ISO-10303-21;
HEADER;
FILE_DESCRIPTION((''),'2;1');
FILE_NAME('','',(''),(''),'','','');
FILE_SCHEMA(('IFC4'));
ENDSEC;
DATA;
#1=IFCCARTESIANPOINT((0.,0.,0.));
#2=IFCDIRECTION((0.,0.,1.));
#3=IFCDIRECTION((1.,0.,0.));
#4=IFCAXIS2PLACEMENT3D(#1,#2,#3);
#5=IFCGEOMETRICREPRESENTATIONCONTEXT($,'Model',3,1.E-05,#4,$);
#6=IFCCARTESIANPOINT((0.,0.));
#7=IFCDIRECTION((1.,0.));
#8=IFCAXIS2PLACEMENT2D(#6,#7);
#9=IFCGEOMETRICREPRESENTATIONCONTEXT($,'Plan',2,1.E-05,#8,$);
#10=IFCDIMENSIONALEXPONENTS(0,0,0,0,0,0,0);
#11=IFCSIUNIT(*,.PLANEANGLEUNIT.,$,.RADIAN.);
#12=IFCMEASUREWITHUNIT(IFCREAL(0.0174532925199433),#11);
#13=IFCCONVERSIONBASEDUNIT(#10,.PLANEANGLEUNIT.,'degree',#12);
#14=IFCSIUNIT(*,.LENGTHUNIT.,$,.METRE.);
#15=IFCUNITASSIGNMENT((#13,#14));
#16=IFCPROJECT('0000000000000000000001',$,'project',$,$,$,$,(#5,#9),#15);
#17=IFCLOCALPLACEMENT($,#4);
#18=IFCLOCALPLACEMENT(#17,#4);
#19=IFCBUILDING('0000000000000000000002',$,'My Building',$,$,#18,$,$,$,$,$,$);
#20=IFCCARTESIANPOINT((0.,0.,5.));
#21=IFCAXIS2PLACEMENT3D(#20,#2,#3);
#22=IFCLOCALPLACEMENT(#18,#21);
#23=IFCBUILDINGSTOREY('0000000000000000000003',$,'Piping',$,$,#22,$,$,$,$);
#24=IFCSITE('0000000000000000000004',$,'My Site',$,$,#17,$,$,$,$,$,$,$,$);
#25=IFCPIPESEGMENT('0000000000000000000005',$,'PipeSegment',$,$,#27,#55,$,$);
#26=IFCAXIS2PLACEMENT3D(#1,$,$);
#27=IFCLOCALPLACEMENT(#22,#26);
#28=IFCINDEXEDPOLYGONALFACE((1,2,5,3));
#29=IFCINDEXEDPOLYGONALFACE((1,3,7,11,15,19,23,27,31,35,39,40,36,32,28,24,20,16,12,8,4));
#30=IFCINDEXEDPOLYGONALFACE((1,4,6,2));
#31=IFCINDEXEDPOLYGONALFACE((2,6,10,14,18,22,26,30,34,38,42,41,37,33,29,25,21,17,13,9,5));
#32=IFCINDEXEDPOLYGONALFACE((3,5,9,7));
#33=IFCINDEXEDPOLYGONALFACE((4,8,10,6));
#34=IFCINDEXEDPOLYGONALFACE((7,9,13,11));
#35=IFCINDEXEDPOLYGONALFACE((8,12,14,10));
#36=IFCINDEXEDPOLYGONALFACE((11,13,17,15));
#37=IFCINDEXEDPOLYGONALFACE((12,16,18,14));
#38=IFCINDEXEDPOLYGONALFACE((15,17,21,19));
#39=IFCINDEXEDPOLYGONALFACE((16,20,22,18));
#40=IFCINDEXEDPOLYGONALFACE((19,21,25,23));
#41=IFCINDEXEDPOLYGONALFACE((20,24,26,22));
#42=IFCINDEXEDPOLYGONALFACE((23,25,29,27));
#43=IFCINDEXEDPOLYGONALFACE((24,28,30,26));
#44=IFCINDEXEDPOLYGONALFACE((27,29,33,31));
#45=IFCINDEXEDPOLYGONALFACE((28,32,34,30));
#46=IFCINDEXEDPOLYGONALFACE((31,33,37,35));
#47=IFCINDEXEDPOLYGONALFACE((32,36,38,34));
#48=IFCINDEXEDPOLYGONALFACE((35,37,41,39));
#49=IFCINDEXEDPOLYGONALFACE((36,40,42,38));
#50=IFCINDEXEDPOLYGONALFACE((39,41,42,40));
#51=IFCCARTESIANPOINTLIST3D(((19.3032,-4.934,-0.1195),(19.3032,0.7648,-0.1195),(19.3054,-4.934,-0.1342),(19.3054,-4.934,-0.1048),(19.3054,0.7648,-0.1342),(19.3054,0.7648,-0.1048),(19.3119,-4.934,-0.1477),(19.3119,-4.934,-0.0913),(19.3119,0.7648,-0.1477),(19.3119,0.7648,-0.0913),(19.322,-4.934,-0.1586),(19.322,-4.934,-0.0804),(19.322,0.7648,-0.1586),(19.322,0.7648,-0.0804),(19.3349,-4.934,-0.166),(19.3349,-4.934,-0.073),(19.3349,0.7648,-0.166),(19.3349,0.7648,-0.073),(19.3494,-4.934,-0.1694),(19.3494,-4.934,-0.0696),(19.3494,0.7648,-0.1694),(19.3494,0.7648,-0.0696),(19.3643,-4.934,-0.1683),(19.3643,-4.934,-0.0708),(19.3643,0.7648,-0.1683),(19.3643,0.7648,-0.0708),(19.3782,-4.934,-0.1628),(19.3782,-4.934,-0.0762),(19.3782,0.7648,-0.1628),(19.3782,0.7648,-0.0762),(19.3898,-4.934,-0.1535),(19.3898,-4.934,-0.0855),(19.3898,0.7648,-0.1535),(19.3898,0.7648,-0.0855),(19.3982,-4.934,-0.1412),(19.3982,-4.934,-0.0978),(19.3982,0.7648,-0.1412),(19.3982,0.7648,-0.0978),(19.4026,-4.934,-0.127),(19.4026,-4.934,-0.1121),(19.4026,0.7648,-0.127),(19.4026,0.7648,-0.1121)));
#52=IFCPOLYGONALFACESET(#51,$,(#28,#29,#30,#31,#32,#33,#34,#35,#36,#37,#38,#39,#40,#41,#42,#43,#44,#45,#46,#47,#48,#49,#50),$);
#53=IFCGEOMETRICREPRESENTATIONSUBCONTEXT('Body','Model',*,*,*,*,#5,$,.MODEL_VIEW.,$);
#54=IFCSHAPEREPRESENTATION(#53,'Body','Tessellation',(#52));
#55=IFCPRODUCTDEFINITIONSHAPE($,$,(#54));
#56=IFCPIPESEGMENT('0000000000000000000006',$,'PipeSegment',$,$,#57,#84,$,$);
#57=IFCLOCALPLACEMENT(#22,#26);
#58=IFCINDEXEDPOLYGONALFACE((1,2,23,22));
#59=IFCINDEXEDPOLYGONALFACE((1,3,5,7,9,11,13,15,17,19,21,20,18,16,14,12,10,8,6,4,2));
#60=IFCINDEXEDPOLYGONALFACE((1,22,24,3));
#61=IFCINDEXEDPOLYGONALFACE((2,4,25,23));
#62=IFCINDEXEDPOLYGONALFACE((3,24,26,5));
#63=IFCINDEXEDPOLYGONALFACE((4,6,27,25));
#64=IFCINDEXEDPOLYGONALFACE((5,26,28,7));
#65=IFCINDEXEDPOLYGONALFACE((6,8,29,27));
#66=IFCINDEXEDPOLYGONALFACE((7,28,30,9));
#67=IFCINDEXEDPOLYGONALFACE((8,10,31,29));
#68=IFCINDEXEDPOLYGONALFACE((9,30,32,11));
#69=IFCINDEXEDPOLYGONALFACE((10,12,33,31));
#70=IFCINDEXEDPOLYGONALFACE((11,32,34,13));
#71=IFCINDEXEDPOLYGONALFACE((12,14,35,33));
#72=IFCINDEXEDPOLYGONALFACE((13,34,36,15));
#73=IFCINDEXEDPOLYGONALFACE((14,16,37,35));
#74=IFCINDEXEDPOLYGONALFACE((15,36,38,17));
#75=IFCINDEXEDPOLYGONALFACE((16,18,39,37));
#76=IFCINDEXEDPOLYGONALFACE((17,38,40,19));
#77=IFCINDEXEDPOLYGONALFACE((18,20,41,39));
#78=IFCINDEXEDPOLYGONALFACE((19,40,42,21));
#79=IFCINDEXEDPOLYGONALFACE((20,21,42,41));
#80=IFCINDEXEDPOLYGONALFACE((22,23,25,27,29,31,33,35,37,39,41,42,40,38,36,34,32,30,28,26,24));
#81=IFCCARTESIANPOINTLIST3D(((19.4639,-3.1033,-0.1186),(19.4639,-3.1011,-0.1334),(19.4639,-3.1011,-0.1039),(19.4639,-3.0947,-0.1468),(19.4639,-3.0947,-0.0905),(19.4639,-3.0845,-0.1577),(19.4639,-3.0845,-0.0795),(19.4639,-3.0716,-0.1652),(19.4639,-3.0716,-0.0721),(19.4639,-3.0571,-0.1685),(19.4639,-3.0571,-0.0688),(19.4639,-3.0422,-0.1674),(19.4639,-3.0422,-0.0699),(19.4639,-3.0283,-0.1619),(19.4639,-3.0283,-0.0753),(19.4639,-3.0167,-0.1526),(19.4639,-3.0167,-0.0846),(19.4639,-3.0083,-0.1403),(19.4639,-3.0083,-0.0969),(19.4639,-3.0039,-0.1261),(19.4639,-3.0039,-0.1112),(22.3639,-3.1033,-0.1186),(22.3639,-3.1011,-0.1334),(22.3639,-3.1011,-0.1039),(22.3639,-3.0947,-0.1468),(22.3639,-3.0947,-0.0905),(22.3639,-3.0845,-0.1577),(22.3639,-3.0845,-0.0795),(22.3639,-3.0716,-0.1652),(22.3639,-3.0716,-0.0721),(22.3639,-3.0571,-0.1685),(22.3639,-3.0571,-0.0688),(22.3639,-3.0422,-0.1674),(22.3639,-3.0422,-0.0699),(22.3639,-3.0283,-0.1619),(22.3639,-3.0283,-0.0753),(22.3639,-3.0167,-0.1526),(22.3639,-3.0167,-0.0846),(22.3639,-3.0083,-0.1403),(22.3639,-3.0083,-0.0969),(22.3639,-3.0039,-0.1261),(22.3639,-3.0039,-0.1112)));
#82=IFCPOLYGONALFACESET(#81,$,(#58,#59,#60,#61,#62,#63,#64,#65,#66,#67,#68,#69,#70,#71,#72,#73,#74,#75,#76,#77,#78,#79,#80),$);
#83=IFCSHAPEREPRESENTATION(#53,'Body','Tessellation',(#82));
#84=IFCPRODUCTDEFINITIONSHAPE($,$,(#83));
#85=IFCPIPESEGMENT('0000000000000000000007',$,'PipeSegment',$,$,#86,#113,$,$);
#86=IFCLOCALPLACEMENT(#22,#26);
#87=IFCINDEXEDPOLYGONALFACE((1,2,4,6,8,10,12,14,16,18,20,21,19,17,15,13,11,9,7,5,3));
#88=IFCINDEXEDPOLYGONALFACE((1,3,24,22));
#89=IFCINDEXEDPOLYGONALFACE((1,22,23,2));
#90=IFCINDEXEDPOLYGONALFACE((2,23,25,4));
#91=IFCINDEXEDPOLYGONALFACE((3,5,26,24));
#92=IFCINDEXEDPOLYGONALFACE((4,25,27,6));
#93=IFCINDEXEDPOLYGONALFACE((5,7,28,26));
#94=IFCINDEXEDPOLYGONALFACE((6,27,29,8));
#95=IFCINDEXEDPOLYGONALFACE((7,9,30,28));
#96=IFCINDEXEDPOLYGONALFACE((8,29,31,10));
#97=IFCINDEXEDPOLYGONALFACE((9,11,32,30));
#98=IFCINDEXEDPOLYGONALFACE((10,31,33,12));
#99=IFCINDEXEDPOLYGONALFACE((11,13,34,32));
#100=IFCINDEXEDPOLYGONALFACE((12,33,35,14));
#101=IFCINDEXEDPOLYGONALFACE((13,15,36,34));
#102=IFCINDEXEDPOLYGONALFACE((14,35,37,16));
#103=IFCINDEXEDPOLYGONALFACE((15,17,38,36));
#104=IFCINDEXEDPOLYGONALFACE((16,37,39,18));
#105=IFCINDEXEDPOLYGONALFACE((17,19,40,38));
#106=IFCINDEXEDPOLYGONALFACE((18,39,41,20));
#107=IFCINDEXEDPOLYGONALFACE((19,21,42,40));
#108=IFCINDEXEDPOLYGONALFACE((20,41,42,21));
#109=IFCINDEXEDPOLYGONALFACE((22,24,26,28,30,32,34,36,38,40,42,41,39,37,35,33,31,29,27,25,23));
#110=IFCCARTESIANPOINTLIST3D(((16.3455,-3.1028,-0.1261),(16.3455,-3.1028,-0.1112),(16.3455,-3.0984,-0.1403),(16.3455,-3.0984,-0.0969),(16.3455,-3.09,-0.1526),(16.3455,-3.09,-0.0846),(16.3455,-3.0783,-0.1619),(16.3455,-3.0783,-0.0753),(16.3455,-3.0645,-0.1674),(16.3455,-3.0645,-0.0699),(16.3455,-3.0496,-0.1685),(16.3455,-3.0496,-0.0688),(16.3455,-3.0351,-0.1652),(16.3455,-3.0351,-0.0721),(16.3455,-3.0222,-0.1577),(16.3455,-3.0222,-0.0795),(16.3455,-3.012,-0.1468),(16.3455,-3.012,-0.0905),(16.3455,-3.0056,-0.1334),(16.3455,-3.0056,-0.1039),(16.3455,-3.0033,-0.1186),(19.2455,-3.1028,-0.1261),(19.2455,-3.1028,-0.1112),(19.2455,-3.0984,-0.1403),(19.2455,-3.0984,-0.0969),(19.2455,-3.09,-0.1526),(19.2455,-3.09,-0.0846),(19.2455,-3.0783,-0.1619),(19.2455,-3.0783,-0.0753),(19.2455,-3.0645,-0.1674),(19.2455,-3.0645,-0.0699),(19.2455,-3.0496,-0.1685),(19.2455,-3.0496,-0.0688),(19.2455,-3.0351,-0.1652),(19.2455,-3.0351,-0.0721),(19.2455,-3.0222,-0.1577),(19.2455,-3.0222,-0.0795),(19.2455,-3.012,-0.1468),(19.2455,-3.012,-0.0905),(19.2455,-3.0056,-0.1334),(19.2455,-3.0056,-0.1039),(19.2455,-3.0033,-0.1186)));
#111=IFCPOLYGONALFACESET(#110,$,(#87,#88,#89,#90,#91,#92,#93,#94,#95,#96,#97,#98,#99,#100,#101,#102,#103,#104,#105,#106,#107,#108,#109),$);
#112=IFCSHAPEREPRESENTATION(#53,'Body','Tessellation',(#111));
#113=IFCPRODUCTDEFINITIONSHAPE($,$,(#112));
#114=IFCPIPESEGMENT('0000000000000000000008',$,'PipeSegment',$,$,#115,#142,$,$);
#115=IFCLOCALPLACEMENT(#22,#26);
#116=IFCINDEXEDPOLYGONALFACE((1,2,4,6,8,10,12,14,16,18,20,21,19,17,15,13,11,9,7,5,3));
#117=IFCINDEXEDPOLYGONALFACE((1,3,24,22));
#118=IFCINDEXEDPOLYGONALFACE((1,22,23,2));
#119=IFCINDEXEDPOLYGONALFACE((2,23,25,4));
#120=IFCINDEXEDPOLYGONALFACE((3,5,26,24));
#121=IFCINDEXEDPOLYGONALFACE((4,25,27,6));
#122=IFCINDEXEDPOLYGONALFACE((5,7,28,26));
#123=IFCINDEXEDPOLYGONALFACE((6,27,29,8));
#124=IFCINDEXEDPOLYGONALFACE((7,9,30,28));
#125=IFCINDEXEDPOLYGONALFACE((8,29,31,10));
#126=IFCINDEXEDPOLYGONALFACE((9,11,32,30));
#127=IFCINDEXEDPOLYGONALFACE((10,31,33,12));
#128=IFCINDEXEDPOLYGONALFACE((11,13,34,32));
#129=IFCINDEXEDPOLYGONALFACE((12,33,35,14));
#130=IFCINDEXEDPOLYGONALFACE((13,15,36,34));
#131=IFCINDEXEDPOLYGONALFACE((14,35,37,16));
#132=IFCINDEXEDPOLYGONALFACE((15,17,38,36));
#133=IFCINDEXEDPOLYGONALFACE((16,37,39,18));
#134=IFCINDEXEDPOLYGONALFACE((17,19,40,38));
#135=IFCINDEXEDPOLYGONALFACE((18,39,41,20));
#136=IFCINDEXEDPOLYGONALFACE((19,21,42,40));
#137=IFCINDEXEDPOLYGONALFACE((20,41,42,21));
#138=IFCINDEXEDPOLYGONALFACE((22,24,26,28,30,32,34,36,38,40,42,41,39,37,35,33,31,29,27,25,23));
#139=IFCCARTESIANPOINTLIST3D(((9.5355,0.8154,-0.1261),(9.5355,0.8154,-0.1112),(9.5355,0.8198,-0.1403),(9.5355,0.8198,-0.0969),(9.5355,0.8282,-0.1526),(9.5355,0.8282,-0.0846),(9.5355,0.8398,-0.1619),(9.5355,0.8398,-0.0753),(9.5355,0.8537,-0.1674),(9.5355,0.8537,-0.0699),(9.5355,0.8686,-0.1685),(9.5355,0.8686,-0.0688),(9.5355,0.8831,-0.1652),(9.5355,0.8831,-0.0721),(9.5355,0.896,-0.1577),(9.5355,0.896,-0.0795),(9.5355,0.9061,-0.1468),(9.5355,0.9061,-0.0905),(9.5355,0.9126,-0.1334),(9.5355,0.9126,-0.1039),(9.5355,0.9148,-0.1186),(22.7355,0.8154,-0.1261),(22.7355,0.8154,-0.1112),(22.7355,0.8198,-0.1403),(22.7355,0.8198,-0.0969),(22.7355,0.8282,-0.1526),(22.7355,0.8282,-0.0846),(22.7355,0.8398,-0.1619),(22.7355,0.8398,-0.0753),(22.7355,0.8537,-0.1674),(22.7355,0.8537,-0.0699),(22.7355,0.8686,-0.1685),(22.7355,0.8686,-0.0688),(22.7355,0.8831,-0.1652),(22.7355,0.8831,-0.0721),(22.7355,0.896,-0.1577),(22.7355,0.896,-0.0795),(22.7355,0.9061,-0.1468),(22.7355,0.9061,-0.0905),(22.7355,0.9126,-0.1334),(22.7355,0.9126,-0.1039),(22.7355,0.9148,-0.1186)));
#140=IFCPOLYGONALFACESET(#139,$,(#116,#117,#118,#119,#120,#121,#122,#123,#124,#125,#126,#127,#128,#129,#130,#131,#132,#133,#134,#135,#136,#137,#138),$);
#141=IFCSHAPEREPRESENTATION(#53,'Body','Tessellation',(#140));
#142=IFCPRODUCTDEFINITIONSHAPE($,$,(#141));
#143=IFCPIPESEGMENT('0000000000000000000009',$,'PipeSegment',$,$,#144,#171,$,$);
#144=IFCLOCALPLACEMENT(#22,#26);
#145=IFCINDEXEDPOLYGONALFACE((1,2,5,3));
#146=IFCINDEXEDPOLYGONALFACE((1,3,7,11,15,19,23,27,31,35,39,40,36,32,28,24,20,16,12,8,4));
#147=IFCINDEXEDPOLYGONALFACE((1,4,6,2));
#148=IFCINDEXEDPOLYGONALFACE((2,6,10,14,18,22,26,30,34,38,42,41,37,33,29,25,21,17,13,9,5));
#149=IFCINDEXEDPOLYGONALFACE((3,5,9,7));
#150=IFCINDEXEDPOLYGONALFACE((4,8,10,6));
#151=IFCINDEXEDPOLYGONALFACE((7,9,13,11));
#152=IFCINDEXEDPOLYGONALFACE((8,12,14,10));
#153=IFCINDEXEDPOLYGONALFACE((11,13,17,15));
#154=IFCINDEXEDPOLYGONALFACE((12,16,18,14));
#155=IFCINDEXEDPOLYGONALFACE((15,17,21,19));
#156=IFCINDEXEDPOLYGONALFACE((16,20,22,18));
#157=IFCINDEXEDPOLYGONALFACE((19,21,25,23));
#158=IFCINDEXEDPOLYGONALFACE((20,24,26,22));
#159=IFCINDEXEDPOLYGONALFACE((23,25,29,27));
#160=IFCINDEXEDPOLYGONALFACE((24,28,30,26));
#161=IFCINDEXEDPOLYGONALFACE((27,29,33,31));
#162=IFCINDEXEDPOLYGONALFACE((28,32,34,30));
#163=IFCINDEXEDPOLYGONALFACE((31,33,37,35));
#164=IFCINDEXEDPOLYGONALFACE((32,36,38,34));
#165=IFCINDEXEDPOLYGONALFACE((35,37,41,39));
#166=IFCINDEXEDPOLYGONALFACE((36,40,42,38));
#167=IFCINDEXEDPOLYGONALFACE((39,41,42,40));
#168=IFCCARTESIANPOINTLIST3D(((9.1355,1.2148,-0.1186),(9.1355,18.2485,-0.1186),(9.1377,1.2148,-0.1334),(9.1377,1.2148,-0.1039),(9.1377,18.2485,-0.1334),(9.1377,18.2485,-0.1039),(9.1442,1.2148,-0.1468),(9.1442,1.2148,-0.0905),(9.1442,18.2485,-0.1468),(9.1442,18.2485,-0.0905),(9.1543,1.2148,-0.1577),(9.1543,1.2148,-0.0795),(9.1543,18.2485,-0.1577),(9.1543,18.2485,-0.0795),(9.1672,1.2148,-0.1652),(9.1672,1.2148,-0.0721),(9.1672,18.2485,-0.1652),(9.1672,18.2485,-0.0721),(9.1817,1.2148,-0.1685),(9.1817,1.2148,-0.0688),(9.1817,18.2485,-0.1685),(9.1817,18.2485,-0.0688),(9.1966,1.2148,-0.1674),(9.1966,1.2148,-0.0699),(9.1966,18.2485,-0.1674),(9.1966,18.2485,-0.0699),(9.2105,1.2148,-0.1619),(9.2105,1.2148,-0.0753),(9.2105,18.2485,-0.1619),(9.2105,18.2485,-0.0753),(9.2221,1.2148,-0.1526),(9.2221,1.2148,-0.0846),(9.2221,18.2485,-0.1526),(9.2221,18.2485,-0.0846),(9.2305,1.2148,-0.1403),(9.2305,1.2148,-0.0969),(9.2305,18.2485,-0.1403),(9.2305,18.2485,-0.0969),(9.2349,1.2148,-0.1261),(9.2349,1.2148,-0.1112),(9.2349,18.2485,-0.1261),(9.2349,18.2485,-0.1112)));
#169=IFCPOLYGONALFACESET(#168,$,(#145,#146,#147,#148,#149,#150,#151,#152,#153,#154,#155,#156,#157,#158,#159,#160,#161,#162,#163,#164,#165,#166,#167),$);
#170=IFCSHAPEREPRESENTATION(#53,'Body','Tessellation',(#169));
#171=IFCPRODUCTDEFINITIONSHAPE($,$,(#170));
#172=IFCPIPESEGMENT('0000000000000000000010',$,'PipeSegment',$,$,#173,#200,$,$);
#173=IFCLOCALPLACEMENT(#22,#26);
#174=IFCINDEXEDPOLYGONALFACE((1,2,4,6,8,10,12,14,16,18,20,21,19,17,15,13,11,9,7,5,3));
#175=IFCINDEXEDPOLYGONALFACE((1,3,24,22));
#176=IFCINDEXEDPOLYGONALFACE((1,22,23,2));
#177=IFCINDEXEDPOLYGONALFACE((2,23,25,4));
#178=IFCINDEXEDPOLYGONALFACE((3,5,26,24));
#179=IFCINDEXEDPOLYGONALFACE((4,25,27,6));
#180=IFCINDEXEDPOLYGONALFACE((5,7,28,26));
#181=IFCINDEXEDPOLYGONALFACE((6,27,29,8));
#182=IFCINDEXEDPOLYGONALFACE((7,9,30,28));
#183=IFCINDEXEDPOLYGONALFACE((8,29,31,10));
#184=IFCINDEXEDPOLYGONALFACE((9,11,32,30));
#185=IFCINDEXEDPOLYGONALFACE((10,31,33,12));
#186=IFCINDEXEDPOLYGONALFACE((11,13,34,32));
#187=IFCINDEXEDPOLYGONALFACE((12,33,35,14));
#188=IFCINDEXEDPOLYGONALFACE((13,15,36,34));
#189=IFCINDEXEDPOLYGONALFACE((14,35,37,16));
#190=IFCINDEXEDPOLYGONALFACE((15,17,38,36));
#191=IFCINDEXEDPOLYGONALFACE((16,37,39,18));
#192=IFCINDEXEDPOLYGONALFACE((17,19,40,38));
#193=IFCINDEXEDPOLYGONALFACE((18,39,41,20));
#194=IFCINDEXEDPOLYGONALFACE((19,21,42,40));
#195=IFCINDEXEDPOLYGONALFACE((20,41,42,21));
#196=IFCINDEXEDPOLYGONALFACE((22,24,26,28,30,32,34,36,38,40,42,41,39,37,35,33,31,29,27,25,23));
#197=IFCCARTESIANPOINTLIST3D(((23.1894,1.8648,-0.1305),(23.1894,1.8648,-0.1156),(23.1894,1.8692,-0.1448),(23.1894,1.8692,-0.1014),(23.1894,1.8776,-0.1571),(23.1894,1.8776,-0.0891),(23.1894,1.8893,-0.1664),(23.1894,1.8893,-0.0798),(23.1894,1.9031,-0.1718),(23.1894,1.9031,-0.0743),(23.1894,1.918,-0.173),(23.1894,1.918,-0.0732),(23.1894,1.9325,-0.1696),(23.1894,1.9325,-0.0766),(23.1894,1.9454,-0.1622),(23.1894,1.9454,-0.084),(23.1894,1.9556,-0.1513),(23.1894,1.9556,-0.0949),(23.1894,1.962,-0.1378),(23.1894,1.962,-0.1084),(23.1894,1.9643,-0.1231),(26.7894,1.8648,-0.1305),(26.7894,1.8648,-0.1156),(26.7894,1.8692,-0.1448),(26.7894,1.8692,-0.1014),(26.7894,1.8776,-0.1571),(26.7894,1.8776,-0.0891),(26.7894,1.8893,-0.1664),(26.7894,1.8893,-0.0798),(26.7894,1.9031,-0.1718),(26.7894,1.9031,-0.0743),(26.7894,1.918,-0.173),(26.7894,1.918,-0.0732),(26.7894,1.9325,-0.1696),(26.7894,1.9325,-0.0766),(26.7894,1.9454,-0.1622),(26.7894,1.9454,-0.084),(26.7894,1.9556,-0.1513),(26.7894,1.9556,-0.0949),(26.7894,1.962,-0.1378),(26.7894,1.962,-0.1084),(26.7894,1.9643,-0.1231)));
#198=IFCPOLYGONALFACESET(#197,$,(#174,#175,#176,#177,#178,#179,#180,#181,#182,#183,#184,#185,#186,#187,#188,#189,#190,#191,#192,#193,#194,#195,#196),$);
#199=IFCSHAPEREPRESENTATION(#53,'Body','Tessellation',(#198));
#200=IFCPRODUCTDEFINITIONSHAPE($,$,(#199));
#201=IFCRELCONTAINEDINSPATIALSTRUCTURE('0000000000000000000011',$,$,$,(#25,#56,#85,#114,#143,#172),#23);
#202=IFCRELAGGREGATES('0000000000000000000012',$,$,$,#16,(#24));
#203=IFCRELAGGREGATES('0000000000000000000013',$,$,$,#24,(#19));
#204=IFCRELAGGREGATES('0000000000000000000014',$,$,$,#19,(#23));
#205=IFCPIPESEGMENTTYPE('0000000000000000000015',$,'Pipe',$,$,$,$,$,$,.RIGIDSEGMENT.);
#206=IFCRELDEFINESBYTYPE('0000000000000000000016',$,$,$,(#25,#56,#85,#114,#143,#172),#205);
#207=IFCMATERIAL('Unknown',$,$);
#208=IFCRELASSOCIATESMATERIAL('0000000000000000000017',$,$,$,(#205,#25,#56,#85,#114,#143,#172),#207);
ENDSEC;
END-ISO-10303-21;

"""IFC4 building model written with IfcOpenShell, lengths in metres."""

from ifc_helpers import new_model, entity, si_unit, converted_unit, frame, origin_with_axes, origin_2d_with_axis, place, context, subcontext, project, spatial, circle, extrude, material, material_profile, profile_set, profile_usage, type_object, element, save


model = new_model("IFC4")

# Units and contexts
model_context = context("Model", 3, precision=1e-05, world=origin_with_axes())
plan_context = context("Plan", 2, precision=1e-05, world=origin_2d_with_axis())
body_context = subcontext(model_context, "Body", "Model", "MODEL_VIEW")
ifc_project = project(units=[converted_unit("PLANEANGLEUNIT", "degree", entity("IfcReal", 0.0174532925199433), si_unit("PLANEANGLEUNIT", "RADIAN"), dimensions=[0, 0, 0, 0, 0, 0, 0]), si_unit("LENGTHUNIT", "METRE")], contexts=[model_context, plan_context])

# Site, building, storey
site_placement = place(None, origin_with_axes())
site = spatial("IfcSite", under=ifc_project, at=site_placement, Name="My Site")
building_placement = place(site_placement, origin_with_axes())
building = spatial("IfcBuilding", under=site, at=building_placement, Name="My Building")
storey_placement = place(building_placement, frame((0.0, 0.0, 5.0), z_axis=(0.0, 0.0, 1.0), x_axis=(1.0, 0.0, 0.0)))
storey = spatial("IfcBuildingStorey", under=building, at=storey_placement, Name="Piping")

# Pipe segments
ifc_material = material(Name="Unknown")
ifc_material_profile_1 = material_profile(ifc_material, circle(Radius=0.05))
ifc_profile_set_1 = profile_set([ifc_material_profile_1])
ifc_profile_usage_1 = profile_usage(ifc_profile_set_1, cardinal=5)
pipe_segment_type = type_object("IfcPipeSegmentType", Name="Pipe", PredefinedType="RIGIDSEGMENT", material=ifc_profile_set_1)
pipe_segment_1_placement = place(storey_placement, frame((19.3532, -4.934, -0.1195), z_axis=(0.0, 1.0, 0.0), x_axis=(-1.0, 0.0, 0.0)))
element("IfcPipeSegment", 1, at=pipe_segment_1_placement, inside=storey, type_object=pipe_segment_type, material=ifc_profile_usage_1, Name="PipeSegment", context=body_context, shape_type="SweptSolid", body=[
    extrude(circle(Radius=0.05), origin_with_axes(), (0.0, 0.0, 1.0), 5.6988),
])
ifc_profile_usage_2 = profile_usage(ifc_profile_set_1, cardinal=5)
pipe_segment_2_placement = place(storey_placement, frame((22.3639, -3.0533, -0.1186), z_axis=(-1.0, 0.0, 0.0), x_axis=(0.0, -1.0, 0.0)))
element("IfcPipeSegment", 2, at=pipe_segment_2_placement, inside=storey, type_object=pipe_segment_type, material=ifc_profile_usage_2, Name="PipeSegment", context=body_context, shape_type="SweptSolid", body=[
    extrude(circle(Radius=0.05), origin_with_axes(), (0.0, 0.0, 1.0), 2.9),
])
ifc_profile_usage_3 = profile_usage(ifc_profile_set_1, cardinal=5)
pipe_segment_3_placement = place(storey_placement, frame((16.3455, -3.0533, -0.1186), z_axis=(1.0, 0.0, 0.0), x_axis=(0.0, 1.0, 0.0)))
element("IfcPipeSegment", 3, at=pipe_segment_3_placement, inside=storey, type_object=pipe_segment_type, material=ifc_profile_usage_3, Name="PipeSegment", context=body_context, shape_type="SweptSolid", body=[
    extrude(circle(Radius=0.05), origin_with_axes(), (0.0, 0.0, 1.0), 2.9),
])
ifc_profile_usage_4 = profile_usage(ifc_profile_set_1, cardinal=5)
pipe_segment_4_placement = place(storey_placement, frame((9.5355, 0.8648, -0.1186), z_axis=(1.0, 0.0, 0.0), x_axis=(0.0, 1.0, 0.0)))
element("IfcPipeSegment", 4, at=pipe_segment_4_placement, inside=storey, type_object=pipe_segment_type, material=ifc_profile_usage_4, Name="PipeSegment", context=body_context, shape_type="SweptSolid", body=[
    extrude(circle(Radius=0.05), origin_with_axes(), (0.0, 0.0, 1.0), 13.2),
])
ifc_profile_usage_5 = profile_usage(ifc_profile_set_1, cardinal=5)
pipe_segment_5_placement = place(storey_placement, frame((9.1855, 1.2148, -0.1186), z_axis=(0.0, 1.0, 0.0), x_axis=(-1.0, 0.0, 0.0)))
element("IfcPipeSegment", 5, at=pipe_segment_5_placement, inside=storey, type_object=pipe_segment_type, material=ifc_profile_usage_5, Name="PipeSegment", context=body_context, shape_type="SweptSolid", body=[
    extrude(circle(Radius=0.05), origin_with_axes(), (0.0, 0.0, 1.0), 17.0337),
])
ifc_profile_usage_6 = profile_usage(ifc_profile_set_1, cardinal=5)
pipe_segment_6_placement = place(storey_placement, frame((23.1894, 1.9143, -0.1231), z_axis=(1.0, 0.0, 0.0), x_axis=(0.0, 1.0, 0.0)))
element("IfcPipeSegment", 6, at=pipe_segment_6_placement, inside=storey, type_object=pipe_segment_type, material=ifc_profile_usage_6, Name="PipeSegment", context=body_context, shape_type="SweptSolid", body=[
    extrude(circle(Radius=0.05), origin_with_axes(), (0.0, 0.0, 1.0), 3.6),
])

save(model, "model.ifc")
